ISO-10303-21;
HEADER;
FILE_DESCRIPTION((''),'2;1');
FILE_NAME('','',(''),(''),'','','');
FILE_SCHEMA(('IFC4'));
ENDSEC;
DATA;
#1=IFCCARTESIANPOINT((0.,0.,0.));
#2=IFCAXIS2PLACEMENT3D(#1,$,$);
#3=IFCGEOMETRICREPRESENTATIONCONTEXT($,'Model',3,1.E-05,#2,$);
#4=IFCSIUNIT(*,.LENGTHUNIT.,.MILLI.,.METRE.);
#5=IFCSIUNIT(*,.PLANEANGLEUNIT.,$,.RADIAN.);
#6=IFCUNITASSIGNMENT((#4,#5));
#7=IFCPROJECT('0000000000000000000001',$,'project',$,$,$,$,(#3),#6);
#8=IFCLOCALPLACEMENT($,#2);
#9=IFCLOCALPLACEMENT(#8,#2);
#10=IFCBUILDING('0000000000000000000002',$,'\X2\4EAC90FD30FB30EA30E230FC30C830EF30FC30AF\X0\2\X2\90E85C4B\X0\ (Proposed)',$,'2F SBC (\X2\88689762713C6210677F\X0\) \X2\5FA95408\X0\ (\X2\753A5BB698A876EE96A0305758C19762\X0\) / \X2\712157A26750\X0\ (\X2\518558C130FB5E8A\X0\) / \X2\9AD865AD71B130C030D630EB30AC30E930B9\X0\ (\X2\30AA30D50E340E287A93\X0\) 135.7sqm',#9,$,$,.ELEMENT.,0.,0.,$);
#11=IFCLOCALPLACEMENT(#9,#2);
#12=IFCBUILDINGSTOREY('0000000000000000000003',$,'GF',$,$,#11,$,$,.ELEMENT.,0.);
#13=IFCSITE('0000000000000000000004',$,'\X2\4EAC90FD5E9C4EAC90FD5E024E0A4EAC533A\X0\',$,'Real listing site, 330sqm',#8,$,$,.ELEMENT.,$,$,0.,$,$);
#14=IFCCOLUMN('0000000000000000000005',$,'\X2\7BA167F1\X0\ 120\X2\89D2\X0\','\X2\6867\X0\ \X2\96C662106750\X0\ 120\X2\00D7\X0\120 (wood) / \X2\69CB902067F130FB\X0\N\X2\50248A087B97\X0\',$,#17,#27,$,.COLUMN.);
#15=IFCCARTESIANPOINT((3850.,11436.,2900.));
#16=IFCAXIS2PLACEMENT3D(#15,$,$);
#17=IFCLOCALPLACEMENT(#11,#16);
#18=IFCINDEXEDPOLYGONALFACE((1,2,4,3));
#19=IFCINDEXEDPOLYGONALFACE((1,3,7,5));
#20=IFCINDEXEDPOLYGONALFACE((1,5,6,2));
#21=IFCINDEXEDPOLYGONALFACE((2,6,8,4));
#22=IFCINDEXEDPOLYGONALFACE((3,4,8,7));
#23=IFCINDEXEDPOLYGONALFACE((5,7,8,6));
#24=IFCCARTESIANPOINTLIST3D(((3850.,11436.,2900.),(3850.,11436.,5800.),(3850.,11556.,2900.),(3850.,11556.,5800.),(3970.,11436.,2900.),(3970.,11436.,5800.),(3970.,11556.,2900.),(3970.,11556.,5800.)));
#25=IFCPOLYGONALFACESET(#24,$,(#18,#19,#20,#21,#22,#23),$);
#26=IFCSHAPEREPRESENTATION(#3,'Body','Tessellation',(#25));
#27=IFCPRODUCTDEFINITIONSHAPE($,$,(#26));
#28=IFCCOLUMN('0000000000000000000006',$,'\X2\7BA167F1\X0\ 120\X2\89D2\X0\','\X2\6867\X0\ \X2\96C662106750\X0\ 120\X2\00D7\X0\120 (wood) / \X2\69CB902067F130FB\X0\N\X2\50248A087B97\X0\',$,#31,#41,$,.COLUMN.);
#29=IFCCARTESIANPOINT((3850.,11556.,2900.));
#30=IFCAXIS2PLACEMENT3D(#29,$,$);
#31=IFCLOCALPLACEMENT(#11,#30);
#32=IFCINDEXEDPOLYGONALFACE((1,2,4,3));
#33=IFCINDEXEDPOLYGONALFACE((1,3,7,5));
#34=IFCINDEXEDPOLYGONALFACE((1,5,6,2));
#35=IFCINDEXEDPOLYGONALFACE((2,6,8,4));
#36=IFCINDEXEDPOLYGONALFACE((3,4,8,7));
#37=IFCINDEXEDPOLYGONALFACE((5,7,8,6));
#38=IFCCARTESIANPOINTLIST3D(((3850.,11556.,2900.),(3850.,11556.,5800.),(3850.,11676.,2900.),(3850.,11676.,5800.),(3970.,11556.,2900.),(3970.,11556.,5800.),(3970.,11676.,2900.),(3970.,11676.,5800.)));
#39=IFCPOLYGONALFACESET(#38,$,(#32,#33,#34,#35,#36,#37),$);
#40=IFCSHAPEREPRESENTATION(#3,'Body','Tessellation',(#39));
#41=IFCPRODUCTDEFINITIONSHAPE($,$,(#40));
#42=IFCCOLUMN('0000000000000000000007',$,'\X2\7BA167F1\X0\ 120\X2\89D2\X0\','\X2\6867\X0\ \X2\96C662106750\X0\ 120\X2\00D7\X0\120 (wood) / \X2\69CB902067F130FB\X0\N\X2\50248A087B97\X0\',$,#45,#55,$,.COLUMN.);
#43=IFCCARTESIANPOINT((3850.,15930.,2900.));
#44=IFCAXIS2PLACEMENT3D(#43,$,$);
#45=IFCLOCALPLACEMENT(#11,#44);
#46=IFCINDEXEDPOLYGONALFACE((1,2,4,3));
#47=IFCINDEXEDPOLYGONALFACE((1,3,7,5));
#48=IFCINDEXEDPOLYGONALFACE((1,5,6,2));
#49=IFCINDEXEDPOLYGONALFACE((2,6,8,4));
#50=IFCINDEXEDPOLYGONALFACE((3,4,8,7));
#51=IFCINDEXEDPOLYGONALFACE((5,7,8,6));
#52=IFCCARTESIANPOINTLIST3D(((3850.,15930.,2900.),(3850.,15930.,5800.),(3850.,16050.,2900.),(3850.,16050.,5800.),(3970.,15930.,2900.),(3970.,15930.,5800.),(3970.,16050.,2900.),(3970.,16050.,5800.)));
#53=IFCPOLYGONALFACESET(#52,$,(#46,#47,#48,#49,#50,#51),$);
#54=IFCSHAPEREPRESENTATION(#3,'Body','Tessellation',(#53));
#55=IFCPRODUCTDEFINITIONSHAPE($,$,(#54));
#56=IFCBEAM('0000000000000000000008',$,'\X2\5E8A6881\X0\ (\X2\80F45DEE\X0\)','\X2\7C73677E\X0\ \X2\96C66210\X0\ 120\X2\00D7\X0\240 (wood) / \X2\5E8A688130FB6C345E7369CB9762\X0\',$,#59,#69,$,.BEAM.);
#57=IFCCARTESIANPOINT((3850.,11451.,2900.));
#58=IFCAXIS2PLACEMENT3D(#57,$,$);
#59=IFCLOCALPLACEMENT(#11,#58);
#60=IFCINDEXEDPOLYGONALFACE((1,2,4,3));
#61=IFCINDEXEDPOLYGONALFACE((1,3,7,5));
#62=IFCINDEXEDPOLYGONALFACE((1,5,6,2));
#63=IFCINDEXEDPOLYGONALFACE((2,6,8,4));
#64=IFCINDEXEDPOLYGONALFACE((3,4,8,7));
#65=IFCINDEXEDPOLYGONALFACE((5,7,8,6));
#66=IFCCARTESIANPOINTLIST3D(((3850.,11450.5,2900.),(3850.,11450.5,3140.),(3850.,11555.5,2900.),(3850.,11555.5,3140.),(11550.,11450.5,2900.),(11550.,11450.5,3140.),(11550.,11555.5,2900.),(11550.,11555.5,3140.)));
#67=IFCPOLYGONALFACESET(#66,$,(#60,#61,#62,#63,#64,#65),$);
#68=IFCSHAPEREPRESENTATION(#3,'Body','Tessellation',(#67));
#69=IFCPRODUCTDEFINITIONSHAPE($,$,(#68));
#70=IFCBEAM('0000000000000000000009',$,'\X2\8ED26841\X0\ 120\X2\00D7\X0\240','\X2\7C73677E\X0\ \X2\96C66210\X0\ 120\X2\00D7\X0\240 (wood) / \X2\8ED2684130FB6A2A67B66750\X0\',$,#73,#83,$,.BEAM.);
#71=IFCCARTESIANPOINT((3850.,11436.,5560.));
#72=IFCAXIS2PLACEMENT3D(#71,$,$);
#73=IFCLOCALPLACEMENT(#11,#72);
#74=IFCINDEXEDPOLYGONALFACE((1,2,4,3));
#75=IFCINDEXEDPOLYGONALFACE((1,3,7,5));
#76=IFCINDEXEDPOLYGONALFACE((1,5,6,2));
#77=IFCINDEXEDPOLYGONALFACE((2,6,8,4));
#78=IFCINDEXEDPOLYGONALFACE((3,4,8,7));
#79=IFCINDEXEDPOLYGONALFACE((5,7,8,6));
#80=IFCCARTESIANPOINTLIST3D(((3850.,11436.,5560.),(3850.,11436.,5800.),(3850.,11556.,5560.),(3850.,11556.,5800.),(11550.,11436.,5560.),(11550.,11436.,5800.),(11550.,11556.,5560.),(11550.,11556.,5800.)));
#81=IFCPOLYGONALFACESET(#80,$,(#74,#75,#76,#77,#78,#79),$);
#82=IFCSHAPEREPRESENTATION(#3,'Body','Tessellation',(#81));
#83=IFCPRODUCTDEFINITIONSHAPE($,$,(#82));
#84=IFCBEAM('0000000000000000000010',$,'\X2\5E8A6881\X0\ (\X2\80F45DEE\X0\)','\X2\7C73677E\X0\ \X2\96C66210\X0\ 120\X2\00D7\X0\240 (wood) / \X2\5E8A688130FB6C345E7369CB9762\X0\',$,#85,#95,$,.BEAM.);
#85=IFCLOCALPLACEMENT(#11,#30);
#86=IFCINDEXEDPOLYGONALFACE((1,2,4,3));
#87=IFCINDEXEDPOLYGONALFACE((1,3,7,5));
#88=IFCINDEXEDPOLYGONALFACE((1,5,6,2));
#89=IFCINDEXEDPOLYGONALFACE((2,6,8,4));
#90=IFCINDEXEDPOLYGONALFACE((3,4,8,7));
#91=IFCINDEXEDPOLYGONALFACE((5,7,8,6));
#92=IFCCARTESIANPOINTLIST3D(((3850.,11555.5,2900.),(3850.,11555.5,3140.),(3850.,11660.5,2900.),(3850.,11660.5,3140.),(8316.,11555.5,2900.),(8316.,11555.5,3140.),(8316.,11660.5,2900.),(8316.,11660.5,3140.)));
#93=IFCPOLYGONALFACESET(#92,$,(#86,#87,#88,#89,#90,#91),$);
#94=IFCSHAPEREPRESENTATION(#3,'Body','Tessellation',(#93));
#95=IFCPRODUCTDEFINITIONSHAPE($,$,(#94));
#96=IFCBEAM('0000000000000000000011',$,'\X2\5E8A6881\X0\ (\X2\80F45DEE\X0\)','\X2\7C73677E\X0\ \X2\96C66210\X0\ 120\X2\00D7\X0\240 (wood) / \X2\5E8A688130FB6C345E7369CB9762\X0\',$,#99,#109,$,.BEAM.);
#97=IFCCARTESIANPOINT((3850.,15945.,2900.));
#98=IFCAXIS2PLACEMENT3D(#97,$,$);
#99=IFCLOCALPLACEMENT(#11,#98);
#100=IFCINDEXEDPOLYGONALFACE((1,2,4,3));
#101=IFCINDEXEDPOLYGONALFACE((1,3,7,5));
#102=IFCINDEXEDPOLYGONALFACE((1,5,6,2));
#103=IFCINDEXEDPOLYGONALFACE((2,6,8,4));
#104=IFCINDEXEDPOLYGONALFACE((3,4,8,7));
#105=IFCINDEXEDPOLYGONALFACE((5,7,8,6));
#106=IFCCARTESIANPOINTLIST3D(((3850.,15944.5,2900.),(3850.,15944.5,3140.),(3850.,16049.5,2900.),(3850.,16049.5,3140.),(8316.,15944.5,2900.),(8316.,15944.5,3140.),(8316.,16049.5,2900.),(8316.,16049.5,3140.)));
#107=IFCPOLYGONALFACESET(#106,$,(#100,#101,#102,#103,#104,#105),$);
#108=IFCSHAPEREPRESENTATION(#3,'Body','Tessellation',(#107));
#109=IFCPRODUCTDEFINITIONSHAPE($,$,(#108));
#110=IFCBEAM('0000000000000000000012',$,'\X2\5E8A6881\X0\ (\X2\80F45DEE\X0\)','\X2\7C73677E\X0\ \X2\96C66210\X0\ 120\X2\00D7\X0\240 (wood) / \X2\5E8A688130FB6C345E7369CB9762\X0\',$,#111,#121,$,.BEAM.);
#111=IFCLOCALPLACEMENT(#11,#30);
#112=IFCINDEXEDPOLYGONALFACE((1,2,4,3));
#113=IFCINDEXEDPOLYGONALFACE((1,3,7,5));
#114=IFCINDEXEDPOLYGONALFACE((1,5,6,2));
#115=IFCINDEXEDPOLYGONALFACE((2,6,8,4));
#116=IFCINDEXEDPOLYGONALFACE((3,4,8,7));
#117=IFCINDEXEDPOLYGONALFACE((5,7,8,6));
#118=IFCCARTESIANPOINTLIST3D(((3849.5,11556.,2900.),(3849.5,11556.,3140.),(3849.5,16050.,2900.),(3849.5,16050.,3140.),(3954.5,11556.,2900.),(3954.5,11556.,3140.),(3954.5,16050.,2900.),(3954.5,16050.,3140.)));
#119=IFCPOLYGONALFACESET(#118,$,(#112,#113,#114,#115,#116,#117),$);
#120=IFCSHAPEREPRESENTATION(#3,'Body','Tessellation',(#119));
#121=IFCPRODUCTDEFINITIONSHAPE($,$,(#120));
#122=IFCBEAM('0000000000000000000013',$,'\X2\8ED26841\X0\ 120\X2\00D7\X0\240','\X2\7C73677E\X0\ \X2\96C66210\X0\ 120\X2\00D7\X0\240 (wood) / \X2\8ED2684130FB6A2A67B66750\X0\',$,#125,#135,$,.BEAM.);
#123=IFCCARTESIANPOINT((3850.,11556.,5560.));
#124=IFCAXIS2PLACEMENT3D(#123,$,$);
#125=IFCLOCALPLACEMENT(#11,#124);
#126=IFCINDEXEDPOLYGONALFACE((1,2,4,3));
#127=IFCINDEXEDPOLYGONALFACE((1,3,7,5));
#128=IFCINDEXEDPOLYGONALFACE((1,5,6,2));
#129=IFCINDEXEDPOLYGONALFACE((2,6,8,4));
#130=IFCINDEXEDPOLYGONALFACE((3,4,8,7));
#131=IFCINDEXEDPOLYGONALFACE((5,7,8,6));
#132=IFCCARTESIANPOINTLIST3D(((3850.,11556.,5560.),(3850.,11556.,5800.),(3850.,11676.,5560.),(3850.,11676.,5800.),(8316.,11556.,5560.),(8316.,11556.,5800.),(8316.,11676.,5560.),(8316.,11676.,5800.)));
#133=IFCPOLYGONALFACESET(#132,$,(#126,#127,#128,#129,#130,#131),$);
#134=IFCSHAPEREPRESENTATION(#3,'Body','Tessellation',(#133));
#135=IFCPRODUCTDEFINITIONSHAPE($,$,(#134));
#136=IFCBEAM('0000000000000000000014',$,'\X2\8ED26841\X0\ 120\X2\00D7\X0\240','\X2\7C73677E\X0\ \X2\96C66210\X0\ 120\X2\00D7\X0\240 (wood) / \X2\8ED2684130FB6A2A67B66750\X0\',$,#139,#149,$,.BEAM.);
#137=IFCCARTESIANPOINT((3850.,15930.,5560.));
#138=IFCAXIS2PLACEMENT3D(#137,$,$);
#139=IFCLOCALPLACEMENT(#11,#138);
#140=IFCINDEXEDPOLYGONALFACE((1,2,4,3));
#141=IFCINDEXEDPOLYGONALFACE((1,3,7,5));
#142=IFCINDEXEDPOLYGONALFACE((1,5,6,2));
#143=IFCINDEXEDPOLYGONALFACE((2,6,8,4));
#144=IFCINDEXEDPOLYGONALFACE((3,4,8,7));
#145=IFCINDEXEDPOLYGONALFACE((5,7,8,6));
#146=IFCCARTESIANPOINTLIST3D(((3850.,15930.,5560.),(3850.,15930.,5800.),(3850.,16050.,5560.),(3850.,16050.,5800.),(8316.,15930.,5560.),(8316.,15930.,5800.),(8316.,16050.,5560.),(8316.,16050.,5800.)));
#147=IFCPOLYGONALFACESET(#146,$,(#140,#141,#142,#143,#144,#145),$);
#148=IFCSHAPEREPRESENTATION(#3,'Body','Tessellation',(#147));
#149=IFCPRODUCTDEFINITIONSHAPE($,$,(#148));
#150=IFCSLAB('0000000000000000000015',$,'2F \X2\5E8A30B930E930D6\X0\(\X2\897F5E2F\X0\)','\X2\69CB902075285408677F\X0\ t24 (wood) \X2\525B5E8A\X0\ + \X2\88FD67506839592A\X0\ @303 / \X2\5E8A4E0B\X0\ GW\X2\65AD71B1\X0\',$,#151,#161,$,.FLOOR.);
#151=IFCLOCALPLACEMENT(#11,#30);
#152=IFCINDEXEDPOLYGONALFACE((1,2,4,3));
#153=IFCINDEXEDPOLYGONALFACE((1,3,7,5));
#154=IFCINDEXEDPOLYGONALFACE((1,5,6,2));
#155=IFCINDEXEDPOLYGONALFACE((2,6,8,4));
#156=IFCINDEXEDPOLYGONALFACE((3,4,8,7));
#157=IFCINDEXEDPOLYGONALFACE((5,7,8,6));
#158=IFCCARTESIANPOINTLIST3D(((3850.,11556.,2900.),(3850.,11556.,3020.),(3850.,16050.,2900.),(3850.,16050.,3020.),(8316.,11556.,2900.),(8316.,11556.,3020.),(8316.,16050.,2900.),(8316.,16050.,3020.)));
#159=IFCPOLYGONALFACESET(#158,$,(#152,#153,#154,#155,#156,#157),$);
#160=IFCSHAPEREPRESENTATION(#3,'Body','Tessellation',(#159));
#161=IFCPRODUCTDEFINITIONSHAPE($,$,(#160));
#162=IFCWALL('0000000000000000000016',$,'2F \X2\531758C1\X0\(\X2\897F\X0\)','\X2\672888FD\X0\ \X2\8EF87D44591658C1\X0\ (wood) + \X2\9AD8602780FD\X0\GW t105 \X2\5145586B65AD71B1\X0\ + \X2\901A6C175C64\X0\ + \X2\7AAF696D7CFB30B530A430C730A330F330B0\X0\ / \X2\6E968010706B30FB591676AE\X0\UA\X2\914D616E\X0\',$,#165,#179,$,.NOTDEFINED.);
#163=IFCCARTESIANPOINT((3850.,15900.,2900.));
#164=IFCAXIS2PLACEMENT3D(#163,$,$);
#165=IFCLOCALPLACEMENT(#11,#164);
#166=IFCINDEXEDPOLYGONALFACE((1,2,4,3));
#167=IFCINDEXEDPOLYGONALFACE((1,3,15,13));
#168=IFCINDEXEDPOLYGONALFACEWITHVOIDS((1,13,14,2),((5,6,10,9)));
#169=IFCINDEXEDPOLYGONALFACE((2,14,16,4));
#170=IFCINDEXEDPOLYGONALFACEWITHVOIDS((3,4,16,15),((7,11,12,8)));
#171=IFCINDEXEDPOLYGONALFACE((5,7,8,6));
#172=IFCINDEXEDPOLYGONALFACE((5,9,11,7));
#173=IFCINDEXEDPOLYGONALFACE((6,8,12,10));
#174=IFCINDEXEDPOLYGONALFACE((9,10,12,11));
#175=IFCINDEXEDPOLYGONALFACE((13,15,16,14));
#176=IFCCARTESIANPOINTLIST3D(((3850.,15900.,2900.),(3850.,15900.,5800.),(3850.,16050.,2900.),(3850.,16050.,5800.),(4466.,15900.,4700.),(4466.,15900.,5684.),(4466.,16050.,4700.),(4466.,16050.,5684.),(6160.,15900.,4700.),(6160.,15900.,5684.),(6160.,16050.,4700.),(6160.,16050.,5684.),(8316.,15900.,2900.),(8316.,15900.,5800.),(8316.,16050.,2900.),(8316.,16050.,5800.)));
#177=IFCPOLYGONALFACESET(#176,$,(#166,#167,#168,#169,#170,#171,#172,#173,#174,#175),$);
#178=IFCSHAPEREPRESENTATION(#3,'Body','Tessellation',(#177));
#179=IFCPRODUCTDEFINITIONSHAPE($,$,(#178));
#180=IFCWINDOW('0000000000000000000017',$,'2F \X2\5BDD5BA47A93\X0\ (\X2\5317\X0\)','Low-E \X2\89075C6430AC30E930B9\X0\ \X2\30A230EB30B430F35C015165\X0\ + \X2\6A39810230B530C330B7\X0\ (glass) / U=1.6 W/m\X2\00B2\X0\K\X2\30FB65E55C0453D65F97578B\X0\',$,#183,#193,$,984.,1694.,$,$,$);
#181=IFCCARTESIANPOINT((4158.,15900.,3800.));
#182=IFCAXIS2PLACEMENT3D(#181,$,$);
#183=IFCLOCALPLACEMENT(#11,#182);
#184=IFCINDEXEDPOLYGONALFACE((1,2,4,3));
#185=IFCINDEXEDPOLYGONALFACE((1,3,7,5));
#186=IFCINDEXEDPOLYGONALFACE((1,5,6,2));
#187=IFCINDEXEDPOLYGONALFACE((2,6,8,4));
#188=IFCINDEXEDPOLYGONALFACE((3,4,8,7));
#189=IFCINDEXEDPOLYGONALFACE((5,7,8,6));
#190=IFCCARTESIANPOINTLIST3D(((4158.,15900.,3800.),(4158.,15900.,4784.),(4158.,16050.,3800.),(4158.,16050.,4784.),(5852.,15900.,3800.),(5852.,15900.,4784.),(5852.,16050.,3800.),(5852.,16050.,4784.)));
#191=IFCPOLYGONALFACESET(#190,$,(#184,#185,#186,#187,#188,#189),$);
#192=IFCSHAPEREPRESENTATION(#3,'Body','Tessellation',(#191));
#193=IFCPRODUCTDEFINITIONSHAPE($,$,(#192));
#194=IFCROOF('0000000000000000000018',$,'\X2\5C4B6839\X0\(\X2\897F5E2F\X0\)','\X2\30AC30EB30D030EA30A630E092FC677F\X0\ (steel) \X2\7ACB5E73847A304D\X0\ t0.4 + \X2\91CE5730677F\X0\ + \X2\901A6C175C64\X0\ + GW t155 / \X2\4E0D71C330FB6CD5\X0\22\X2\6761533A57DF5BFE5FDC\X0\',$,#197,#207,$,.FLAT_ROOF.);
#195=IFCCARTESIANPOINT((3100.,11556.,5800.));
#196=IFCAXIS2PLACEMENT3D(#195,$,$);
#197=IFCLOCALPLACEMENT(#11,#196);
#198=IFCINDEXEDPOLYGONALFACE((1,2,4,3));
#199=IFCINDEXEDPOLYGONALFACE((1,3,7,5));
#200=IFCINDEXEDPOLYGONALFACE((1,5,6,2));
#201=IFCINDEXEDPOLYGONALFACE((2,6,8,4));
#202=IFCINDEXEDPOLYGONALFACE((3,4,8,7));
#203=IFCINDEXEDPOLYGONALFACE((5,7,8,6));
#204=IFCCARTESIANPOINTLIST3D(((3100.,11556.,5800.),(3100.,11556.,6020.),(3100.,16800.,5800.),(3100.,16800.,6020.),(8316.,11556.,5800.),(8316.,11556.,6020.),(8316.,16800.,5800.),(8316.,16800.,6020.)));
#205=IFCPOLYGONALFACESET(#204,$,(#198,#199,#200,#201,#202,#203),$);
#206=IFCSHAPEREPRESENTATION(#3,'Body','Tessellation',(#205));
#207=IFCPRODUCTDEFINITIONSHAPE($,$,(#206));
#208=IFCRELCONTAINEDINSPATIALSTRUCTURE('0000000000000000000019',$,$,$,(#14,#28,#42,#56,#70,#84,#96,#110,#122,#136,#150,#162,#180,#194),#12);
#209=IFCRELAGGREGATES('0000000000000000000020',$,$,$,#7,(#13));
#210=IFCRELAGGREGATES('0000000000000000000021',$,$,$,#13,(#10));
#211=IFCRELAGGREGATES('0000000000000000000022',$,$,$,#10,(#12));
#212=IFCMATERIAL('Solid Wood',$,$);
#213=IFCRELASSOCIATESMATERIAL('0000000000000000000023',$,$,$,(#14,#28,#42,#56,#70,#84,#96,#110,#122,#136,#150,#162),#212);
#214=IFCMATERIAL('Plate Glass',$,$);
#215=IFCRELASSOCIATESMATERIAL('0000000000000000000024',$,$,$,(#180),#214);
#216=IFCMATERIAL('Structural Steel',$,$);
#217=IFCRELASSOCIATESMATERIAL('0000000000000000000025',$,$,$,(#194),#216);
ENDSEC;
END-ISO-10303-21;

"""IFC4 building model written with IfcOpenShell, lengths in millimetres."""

from ifc_helpers import new_model, si_unit, frame, frame_2d, origin, place, context, project, spatial, rectangle, extrude, material, element, fill, save


model = new_model("IFC4")

# Units and contexts
model_context = context("Model", 3, precision=1e-05, world=origin())
ifc_project = project(units=[si_unit("LENGTHUNIT", "METRE", prefix="MILLI"), si_unit("PLANEANGLEUNIT", "RADIAN")], contexts=[model_context])

# Site, building, storey
site_placement = place(None, origin())
site = spatial("IfcSite", under=ifc_project, at=site_placement, Name="京都府京都市上京区", ObjectType="Real listing site, 330sqm", CompositionType="ELEMENT", RefElevation=0.0)
building_placement = place(site_placement, origin())
building = spatial("IfcBuilding", under=site, at=building_placement, Name="京都・リモートワーク2部屋 (Proposed)", ObjectType="2F SBC (表面焼成板) 復合 (町家風目隠し壁面) / 無垢材 (内壁・床) / 高断熱ダブルガラス (オフิศ窓) 135.7sqm", CompositionType="ELEMENT", ElevationOfRefHeight=0.0, ElevationOfTerrain=0.0)
storey_placement = place(building_placement, origin())
storey = spatial("IfcBuildingStorey", under=building, at=storey_placement, Name="GF", CompositionType="ELEMENT", Elevation=0.0)

# Columns
ifc_material_1 = material(Name="Solid Wood")
column_1_placement = place(storey_placement, frame((3850.0, 11436.0, 2900.0)))
element("IfcColumn", 1, at=column_1_placement, inside=storey, material=ifc_material_1, Name="管柱 120角", Description="桧 集成材 120×120 (wood) / 構造柱・N値計算", PredefinedType="COLUMN", context=model_context, shape_type="SweptSolid", body=[
    extrude(rectangle(XDim=120.0, YDim=120.0, at=frame_2d((60.0, 60.0))), frame((3850.0, 11436.0, 2900.0)), (0.0, 0.0, 1.0), 2900.0),
])
column_2_placement = place(storey_placement, frame((3850.0, 11556.0, 2900.0)))
element("IfcColumn", 2, at=column_2_placement, inside=storey, material=ifc_material_1, Name="管柱 120角", Description="桧 集成材 120×120 (wood) / 構造柱・N値計算", PredefinedType="COLUMN", context=model_context, shape_type="SweptSolid", body=[
    extrude(rectangle(XDim=120.0, YDim=120.0, at=frame_2d((60.0, 60.0))), frame((3850.0, 11556.0, 2900.0)), (0.0, 0.0, 1.0), 2900.0),
])
column_3_placement = place(storey_placement, frame((3850.0, 15930.0, 2900.0)))
element("IfcColumn", 3, at=column_3_placement, inside=storey, material=ifc_material_1, Name="管柱 120角", Description="桧 集成材 120×120 (wood) / 構造柱・N値計算", PredefinedType="COLUMN", context=model_context, shape_type="SweptSolid", body=[
    extrude(rectangle(XDim=120.0, YDim=120.0, at=frame_2d((60.0, 60.0))), frame((3850.0, 15930.0, 2900.0)), (0.0, 0.0, 1.0), 2900.0),
])

# Beams
beam_1_placement = place(storey_placement, frame((3850.0, 11451.0, 2900.0)))
element("IfcBeam", 4, at=beam_1_placement, inside=storey, material=ifc_material_1, Name="床梁 (胴差)", Description="米松 集成 120×240 (wood) / 床梁・水平構面", PredefinedType="BEAM", context=model_context, shape_type="SweptSolid", body=[
    extrude(rectangle(XDim=7700.0, YDim=105.0, at=frame_2d((3850.0, 52.0))), frame((3850.0, 11451.0, 2900.0)), (0.0, 0.0, 1.0), 240.0),
])
beam_2_placement = place(storey_placement, frame((3850.0, 11436.0, 5560.0)))
element("IfcBeam", 5, at=beam_2_placement, inside=storey, material=ifc_material_1, Name="軒桁 120×240", Description="米松 集成 120×240 (wood) / 軒桁・横架材", PredefinedType="BEAM", context=model_context, shape_type="SweptSolid", body=[
    extrude(rectangle(XDim=7700.0, YDim=120.0, at=frame_2d((3850.0, 60.0))), frame((3850.0, 11436.0, 5560.0)), (0.0, 0.0, 1.0), 240.0),
])
beam_3_placement = place(storey_placement, frame((3850.0, 11556.0, 2900.0)))
element("IfcBeam", 6, at=beam_3_placement, inside=storey, material=ifc_material_1, Name="床梁 (胴差)", Description="米松 集成 120×240 (wood) / 床梁・水平構面", PredefinedType="BEAM", context=model_context, shape_type="SweptSolid", body=[
    extrude(rectangle(XDim=4466.0, YDim=105.0, at=frame_2d((2233.0, 52.0))), frame((3850.0, 11556.0, 2900.0)), (0.0, 0.0, 1.0), 240.0),
])
beam_4_placement = place(storey_placement, frame((3850.0, 15945.0, 2900.0)))
element("IfcBeam", 7, at=beam_4_placement, inside=storey, material=ifc_material_1, Name="床梁 (胴差)", Description="米松 集成 120×240 (wood) / 床梁・水平構面", PredefinedType="BEAM", context=model_context, shape_type="SweptSolid", body=[
    extrude(rectangle(XDim=4466.0, YDim=105.0, at=frame_2d((2233.0, 52.0))), frame((3850.0, 15945.0, 2900.0)), (0.0, 0.0, 1.0), 240.0),
])
beam_5_placement = place(storey_placement, frame((3850.0, 11556.0, 2900.0)))
element("IfcBeam", 8, at=beam_5_placement, inside=storey, material=ifc_material_1, Name="床梁 (胴差)", Description="米松 集成 120×240 (wood) / 床梁・水平構面", PredefinedType="BEAM", context=model_context, shape_type="SweptSolid", body=[
    extrude(rectangle(XDim=105.0, YDim=4494.0, at=frame_2d((52.0, 2247.0))), frame((3850.0, 11556.0, 2900.0)), (0.0, 0.0, 1.0), 240.0),
])
beam_6_placement = place(storey_placement, frame((3850.0, 11556.0, 5560.0)))
element("IfcBeam", 9, at=beam_6_placement, inside=storey, material=ifc_material_1, Name="軒桁 120×240", Description="米松 集成 120×240 (wood) / 軒桁・横架材", PredefinedType="BEAM", context=model_context, shape_type="SweptSolid", body=[
    extrude(rectangle(XDim=4466.0, YDim=120.0, at=frame_2d((2233.0, 60.0))), frame((3850.0, 11556.0, 5560.0)), (0.0, 0.0, 1.0), 240.0),
])
beam_7_placement = place(storey_placement, frame((3850.0, 15930.0, 5560.0)))
element("IfcBeam", 10, at=beam_7_placement, inside=storey, material=ifc_material_1, Name="軒桁 120×240", Description="米松 集成 120×240 (wood) / 軒桁・横架材", PredefinedType="BEAM", context=model_context, shape_type="SweptSolid", body=[
    extrude(rectangle(XDim=4466.0, YDim=120.0, at=frame_2d((2233.0, 60.0))), frame((3850.0, 15930.0, 5560.0)), (0.0, 0.0, 1.0), 240.0),
])

# Slab
slab_placement = place(storey_placement, frame((3850.0, 11556.0, 2900.0)))
element("IfcSlab", 11, at=slab_placement, inside=storey, material=ifc_material_1, Name="2F 床スラブ(西帯)", Description="構造用合板 t24 (wood) 剛床 + 製材根太 @303 / 床下 GW断熱", PredefinedType="FLOOR", context=model_context, shape_type="SweptSolid", body=[
    extrude(rectangle(XDim=4466.0, YDim=4494.0, at=frame_2d((2233.0, 2247.0))), frame((3850.0, 11556.0, 2900.0)), (0.0, 0.0, 1.0), 120.0),
])

# Wall, opening, window
wall_1_placement = place(storey_placement, frame((3850.0, 15900.0, 2900.0)))
wall_1 = element("IfcWall", 12, at=wall_1_placement, inside=storey, material=ifc_material_1, Name="2F 北壁(西)", Description="木製 軸組外壁 (wood) + 高性能GW t105 充填断熱 + 通気層 + 窯業系サイディング / 準耐火・外皮UA配慮", PredefinedType="NOTDEFINED", context=model_context, shape_type="SweptSolid", body=[
    extrude(rectangle(XDim=4466.0, YDim=150.0, at=frame_2d((2233.0, 75.0))), frame((3850.0, 15900.0, 2900.0)), (0.0, 0.0, 1.0), 2900.0),
])
opening_placement = place(storey_placement, frame((4158.0, 15900.0, 3800.0)))
opening = element("IfcOpeningElement", 13, at=opening_placement, cuts=wall_1, PredefinedType="NOTDEFINED", context=model_context, shape_type="SweptSolid", body=[
    extrude(rectangle(XDim=1694.0, YDim=150.0, at=frame_2d((847.0, 75.0))), frame((4158.0, 15900.0, 3800.0)), (0.0, 0.0, 1.0), 984.0),
])
ifc_material_2 = material(Name="Plate Glass")
window_placement = place(storey_placement, frame((4158.0, 15900.0, 3800.0)))
window = element("IfcWindow", 14, at=window_placement, inside=storey, material=ifc_material_2, Name="2F 寝室窓 (北)", Description="Low-E 複層ガラス アルゴン封入 + 樹脂サッシ (glass) / U=1.6 W/m²K・日射取得型", OverallHeight=984.0, OverallWidth=1694.0, context=model_context, shape_type="SweptSolid", body=[
    extrude(rectangle(XDim=1694.0, YDim=150.0, at=frame_2d((847.0, 75.0))), frame((4158.0, 15900.0, 3800.0)), (0.0, 0.0, 1.0), 984.0),
])
fill(opening, window)

# Roof
ifc_material_3 = material(Name="Structural Steel")
for number, where, name in (
    (15, (3100.0, 11556.0, 5800.0), "屋根(西帯)"),
):
    element("IfcRoof", number, at=place(storey_placement, frame(where)), inside=storey, material=ifc_material_3, Name=name, Description="ガルバリウム鋼板 (steel) 立平葺き t0.4 + 野地板 + 通気層 + GW t155 / 不燃・法22条区域対応", PredefinedType="FLAT_ROOF", context=model_context, shape_type="SweptSolid", body=[
        extrude(rectangle(XDim=5216.0, YDim=5244.0, at=frame_2d((2608.0, 2622.0))), frame((3100.0, 11556.0, 5800.0)), (0.0, 0.0, 1.0), 220.0),
    ])

save(model, "model.ifc")
